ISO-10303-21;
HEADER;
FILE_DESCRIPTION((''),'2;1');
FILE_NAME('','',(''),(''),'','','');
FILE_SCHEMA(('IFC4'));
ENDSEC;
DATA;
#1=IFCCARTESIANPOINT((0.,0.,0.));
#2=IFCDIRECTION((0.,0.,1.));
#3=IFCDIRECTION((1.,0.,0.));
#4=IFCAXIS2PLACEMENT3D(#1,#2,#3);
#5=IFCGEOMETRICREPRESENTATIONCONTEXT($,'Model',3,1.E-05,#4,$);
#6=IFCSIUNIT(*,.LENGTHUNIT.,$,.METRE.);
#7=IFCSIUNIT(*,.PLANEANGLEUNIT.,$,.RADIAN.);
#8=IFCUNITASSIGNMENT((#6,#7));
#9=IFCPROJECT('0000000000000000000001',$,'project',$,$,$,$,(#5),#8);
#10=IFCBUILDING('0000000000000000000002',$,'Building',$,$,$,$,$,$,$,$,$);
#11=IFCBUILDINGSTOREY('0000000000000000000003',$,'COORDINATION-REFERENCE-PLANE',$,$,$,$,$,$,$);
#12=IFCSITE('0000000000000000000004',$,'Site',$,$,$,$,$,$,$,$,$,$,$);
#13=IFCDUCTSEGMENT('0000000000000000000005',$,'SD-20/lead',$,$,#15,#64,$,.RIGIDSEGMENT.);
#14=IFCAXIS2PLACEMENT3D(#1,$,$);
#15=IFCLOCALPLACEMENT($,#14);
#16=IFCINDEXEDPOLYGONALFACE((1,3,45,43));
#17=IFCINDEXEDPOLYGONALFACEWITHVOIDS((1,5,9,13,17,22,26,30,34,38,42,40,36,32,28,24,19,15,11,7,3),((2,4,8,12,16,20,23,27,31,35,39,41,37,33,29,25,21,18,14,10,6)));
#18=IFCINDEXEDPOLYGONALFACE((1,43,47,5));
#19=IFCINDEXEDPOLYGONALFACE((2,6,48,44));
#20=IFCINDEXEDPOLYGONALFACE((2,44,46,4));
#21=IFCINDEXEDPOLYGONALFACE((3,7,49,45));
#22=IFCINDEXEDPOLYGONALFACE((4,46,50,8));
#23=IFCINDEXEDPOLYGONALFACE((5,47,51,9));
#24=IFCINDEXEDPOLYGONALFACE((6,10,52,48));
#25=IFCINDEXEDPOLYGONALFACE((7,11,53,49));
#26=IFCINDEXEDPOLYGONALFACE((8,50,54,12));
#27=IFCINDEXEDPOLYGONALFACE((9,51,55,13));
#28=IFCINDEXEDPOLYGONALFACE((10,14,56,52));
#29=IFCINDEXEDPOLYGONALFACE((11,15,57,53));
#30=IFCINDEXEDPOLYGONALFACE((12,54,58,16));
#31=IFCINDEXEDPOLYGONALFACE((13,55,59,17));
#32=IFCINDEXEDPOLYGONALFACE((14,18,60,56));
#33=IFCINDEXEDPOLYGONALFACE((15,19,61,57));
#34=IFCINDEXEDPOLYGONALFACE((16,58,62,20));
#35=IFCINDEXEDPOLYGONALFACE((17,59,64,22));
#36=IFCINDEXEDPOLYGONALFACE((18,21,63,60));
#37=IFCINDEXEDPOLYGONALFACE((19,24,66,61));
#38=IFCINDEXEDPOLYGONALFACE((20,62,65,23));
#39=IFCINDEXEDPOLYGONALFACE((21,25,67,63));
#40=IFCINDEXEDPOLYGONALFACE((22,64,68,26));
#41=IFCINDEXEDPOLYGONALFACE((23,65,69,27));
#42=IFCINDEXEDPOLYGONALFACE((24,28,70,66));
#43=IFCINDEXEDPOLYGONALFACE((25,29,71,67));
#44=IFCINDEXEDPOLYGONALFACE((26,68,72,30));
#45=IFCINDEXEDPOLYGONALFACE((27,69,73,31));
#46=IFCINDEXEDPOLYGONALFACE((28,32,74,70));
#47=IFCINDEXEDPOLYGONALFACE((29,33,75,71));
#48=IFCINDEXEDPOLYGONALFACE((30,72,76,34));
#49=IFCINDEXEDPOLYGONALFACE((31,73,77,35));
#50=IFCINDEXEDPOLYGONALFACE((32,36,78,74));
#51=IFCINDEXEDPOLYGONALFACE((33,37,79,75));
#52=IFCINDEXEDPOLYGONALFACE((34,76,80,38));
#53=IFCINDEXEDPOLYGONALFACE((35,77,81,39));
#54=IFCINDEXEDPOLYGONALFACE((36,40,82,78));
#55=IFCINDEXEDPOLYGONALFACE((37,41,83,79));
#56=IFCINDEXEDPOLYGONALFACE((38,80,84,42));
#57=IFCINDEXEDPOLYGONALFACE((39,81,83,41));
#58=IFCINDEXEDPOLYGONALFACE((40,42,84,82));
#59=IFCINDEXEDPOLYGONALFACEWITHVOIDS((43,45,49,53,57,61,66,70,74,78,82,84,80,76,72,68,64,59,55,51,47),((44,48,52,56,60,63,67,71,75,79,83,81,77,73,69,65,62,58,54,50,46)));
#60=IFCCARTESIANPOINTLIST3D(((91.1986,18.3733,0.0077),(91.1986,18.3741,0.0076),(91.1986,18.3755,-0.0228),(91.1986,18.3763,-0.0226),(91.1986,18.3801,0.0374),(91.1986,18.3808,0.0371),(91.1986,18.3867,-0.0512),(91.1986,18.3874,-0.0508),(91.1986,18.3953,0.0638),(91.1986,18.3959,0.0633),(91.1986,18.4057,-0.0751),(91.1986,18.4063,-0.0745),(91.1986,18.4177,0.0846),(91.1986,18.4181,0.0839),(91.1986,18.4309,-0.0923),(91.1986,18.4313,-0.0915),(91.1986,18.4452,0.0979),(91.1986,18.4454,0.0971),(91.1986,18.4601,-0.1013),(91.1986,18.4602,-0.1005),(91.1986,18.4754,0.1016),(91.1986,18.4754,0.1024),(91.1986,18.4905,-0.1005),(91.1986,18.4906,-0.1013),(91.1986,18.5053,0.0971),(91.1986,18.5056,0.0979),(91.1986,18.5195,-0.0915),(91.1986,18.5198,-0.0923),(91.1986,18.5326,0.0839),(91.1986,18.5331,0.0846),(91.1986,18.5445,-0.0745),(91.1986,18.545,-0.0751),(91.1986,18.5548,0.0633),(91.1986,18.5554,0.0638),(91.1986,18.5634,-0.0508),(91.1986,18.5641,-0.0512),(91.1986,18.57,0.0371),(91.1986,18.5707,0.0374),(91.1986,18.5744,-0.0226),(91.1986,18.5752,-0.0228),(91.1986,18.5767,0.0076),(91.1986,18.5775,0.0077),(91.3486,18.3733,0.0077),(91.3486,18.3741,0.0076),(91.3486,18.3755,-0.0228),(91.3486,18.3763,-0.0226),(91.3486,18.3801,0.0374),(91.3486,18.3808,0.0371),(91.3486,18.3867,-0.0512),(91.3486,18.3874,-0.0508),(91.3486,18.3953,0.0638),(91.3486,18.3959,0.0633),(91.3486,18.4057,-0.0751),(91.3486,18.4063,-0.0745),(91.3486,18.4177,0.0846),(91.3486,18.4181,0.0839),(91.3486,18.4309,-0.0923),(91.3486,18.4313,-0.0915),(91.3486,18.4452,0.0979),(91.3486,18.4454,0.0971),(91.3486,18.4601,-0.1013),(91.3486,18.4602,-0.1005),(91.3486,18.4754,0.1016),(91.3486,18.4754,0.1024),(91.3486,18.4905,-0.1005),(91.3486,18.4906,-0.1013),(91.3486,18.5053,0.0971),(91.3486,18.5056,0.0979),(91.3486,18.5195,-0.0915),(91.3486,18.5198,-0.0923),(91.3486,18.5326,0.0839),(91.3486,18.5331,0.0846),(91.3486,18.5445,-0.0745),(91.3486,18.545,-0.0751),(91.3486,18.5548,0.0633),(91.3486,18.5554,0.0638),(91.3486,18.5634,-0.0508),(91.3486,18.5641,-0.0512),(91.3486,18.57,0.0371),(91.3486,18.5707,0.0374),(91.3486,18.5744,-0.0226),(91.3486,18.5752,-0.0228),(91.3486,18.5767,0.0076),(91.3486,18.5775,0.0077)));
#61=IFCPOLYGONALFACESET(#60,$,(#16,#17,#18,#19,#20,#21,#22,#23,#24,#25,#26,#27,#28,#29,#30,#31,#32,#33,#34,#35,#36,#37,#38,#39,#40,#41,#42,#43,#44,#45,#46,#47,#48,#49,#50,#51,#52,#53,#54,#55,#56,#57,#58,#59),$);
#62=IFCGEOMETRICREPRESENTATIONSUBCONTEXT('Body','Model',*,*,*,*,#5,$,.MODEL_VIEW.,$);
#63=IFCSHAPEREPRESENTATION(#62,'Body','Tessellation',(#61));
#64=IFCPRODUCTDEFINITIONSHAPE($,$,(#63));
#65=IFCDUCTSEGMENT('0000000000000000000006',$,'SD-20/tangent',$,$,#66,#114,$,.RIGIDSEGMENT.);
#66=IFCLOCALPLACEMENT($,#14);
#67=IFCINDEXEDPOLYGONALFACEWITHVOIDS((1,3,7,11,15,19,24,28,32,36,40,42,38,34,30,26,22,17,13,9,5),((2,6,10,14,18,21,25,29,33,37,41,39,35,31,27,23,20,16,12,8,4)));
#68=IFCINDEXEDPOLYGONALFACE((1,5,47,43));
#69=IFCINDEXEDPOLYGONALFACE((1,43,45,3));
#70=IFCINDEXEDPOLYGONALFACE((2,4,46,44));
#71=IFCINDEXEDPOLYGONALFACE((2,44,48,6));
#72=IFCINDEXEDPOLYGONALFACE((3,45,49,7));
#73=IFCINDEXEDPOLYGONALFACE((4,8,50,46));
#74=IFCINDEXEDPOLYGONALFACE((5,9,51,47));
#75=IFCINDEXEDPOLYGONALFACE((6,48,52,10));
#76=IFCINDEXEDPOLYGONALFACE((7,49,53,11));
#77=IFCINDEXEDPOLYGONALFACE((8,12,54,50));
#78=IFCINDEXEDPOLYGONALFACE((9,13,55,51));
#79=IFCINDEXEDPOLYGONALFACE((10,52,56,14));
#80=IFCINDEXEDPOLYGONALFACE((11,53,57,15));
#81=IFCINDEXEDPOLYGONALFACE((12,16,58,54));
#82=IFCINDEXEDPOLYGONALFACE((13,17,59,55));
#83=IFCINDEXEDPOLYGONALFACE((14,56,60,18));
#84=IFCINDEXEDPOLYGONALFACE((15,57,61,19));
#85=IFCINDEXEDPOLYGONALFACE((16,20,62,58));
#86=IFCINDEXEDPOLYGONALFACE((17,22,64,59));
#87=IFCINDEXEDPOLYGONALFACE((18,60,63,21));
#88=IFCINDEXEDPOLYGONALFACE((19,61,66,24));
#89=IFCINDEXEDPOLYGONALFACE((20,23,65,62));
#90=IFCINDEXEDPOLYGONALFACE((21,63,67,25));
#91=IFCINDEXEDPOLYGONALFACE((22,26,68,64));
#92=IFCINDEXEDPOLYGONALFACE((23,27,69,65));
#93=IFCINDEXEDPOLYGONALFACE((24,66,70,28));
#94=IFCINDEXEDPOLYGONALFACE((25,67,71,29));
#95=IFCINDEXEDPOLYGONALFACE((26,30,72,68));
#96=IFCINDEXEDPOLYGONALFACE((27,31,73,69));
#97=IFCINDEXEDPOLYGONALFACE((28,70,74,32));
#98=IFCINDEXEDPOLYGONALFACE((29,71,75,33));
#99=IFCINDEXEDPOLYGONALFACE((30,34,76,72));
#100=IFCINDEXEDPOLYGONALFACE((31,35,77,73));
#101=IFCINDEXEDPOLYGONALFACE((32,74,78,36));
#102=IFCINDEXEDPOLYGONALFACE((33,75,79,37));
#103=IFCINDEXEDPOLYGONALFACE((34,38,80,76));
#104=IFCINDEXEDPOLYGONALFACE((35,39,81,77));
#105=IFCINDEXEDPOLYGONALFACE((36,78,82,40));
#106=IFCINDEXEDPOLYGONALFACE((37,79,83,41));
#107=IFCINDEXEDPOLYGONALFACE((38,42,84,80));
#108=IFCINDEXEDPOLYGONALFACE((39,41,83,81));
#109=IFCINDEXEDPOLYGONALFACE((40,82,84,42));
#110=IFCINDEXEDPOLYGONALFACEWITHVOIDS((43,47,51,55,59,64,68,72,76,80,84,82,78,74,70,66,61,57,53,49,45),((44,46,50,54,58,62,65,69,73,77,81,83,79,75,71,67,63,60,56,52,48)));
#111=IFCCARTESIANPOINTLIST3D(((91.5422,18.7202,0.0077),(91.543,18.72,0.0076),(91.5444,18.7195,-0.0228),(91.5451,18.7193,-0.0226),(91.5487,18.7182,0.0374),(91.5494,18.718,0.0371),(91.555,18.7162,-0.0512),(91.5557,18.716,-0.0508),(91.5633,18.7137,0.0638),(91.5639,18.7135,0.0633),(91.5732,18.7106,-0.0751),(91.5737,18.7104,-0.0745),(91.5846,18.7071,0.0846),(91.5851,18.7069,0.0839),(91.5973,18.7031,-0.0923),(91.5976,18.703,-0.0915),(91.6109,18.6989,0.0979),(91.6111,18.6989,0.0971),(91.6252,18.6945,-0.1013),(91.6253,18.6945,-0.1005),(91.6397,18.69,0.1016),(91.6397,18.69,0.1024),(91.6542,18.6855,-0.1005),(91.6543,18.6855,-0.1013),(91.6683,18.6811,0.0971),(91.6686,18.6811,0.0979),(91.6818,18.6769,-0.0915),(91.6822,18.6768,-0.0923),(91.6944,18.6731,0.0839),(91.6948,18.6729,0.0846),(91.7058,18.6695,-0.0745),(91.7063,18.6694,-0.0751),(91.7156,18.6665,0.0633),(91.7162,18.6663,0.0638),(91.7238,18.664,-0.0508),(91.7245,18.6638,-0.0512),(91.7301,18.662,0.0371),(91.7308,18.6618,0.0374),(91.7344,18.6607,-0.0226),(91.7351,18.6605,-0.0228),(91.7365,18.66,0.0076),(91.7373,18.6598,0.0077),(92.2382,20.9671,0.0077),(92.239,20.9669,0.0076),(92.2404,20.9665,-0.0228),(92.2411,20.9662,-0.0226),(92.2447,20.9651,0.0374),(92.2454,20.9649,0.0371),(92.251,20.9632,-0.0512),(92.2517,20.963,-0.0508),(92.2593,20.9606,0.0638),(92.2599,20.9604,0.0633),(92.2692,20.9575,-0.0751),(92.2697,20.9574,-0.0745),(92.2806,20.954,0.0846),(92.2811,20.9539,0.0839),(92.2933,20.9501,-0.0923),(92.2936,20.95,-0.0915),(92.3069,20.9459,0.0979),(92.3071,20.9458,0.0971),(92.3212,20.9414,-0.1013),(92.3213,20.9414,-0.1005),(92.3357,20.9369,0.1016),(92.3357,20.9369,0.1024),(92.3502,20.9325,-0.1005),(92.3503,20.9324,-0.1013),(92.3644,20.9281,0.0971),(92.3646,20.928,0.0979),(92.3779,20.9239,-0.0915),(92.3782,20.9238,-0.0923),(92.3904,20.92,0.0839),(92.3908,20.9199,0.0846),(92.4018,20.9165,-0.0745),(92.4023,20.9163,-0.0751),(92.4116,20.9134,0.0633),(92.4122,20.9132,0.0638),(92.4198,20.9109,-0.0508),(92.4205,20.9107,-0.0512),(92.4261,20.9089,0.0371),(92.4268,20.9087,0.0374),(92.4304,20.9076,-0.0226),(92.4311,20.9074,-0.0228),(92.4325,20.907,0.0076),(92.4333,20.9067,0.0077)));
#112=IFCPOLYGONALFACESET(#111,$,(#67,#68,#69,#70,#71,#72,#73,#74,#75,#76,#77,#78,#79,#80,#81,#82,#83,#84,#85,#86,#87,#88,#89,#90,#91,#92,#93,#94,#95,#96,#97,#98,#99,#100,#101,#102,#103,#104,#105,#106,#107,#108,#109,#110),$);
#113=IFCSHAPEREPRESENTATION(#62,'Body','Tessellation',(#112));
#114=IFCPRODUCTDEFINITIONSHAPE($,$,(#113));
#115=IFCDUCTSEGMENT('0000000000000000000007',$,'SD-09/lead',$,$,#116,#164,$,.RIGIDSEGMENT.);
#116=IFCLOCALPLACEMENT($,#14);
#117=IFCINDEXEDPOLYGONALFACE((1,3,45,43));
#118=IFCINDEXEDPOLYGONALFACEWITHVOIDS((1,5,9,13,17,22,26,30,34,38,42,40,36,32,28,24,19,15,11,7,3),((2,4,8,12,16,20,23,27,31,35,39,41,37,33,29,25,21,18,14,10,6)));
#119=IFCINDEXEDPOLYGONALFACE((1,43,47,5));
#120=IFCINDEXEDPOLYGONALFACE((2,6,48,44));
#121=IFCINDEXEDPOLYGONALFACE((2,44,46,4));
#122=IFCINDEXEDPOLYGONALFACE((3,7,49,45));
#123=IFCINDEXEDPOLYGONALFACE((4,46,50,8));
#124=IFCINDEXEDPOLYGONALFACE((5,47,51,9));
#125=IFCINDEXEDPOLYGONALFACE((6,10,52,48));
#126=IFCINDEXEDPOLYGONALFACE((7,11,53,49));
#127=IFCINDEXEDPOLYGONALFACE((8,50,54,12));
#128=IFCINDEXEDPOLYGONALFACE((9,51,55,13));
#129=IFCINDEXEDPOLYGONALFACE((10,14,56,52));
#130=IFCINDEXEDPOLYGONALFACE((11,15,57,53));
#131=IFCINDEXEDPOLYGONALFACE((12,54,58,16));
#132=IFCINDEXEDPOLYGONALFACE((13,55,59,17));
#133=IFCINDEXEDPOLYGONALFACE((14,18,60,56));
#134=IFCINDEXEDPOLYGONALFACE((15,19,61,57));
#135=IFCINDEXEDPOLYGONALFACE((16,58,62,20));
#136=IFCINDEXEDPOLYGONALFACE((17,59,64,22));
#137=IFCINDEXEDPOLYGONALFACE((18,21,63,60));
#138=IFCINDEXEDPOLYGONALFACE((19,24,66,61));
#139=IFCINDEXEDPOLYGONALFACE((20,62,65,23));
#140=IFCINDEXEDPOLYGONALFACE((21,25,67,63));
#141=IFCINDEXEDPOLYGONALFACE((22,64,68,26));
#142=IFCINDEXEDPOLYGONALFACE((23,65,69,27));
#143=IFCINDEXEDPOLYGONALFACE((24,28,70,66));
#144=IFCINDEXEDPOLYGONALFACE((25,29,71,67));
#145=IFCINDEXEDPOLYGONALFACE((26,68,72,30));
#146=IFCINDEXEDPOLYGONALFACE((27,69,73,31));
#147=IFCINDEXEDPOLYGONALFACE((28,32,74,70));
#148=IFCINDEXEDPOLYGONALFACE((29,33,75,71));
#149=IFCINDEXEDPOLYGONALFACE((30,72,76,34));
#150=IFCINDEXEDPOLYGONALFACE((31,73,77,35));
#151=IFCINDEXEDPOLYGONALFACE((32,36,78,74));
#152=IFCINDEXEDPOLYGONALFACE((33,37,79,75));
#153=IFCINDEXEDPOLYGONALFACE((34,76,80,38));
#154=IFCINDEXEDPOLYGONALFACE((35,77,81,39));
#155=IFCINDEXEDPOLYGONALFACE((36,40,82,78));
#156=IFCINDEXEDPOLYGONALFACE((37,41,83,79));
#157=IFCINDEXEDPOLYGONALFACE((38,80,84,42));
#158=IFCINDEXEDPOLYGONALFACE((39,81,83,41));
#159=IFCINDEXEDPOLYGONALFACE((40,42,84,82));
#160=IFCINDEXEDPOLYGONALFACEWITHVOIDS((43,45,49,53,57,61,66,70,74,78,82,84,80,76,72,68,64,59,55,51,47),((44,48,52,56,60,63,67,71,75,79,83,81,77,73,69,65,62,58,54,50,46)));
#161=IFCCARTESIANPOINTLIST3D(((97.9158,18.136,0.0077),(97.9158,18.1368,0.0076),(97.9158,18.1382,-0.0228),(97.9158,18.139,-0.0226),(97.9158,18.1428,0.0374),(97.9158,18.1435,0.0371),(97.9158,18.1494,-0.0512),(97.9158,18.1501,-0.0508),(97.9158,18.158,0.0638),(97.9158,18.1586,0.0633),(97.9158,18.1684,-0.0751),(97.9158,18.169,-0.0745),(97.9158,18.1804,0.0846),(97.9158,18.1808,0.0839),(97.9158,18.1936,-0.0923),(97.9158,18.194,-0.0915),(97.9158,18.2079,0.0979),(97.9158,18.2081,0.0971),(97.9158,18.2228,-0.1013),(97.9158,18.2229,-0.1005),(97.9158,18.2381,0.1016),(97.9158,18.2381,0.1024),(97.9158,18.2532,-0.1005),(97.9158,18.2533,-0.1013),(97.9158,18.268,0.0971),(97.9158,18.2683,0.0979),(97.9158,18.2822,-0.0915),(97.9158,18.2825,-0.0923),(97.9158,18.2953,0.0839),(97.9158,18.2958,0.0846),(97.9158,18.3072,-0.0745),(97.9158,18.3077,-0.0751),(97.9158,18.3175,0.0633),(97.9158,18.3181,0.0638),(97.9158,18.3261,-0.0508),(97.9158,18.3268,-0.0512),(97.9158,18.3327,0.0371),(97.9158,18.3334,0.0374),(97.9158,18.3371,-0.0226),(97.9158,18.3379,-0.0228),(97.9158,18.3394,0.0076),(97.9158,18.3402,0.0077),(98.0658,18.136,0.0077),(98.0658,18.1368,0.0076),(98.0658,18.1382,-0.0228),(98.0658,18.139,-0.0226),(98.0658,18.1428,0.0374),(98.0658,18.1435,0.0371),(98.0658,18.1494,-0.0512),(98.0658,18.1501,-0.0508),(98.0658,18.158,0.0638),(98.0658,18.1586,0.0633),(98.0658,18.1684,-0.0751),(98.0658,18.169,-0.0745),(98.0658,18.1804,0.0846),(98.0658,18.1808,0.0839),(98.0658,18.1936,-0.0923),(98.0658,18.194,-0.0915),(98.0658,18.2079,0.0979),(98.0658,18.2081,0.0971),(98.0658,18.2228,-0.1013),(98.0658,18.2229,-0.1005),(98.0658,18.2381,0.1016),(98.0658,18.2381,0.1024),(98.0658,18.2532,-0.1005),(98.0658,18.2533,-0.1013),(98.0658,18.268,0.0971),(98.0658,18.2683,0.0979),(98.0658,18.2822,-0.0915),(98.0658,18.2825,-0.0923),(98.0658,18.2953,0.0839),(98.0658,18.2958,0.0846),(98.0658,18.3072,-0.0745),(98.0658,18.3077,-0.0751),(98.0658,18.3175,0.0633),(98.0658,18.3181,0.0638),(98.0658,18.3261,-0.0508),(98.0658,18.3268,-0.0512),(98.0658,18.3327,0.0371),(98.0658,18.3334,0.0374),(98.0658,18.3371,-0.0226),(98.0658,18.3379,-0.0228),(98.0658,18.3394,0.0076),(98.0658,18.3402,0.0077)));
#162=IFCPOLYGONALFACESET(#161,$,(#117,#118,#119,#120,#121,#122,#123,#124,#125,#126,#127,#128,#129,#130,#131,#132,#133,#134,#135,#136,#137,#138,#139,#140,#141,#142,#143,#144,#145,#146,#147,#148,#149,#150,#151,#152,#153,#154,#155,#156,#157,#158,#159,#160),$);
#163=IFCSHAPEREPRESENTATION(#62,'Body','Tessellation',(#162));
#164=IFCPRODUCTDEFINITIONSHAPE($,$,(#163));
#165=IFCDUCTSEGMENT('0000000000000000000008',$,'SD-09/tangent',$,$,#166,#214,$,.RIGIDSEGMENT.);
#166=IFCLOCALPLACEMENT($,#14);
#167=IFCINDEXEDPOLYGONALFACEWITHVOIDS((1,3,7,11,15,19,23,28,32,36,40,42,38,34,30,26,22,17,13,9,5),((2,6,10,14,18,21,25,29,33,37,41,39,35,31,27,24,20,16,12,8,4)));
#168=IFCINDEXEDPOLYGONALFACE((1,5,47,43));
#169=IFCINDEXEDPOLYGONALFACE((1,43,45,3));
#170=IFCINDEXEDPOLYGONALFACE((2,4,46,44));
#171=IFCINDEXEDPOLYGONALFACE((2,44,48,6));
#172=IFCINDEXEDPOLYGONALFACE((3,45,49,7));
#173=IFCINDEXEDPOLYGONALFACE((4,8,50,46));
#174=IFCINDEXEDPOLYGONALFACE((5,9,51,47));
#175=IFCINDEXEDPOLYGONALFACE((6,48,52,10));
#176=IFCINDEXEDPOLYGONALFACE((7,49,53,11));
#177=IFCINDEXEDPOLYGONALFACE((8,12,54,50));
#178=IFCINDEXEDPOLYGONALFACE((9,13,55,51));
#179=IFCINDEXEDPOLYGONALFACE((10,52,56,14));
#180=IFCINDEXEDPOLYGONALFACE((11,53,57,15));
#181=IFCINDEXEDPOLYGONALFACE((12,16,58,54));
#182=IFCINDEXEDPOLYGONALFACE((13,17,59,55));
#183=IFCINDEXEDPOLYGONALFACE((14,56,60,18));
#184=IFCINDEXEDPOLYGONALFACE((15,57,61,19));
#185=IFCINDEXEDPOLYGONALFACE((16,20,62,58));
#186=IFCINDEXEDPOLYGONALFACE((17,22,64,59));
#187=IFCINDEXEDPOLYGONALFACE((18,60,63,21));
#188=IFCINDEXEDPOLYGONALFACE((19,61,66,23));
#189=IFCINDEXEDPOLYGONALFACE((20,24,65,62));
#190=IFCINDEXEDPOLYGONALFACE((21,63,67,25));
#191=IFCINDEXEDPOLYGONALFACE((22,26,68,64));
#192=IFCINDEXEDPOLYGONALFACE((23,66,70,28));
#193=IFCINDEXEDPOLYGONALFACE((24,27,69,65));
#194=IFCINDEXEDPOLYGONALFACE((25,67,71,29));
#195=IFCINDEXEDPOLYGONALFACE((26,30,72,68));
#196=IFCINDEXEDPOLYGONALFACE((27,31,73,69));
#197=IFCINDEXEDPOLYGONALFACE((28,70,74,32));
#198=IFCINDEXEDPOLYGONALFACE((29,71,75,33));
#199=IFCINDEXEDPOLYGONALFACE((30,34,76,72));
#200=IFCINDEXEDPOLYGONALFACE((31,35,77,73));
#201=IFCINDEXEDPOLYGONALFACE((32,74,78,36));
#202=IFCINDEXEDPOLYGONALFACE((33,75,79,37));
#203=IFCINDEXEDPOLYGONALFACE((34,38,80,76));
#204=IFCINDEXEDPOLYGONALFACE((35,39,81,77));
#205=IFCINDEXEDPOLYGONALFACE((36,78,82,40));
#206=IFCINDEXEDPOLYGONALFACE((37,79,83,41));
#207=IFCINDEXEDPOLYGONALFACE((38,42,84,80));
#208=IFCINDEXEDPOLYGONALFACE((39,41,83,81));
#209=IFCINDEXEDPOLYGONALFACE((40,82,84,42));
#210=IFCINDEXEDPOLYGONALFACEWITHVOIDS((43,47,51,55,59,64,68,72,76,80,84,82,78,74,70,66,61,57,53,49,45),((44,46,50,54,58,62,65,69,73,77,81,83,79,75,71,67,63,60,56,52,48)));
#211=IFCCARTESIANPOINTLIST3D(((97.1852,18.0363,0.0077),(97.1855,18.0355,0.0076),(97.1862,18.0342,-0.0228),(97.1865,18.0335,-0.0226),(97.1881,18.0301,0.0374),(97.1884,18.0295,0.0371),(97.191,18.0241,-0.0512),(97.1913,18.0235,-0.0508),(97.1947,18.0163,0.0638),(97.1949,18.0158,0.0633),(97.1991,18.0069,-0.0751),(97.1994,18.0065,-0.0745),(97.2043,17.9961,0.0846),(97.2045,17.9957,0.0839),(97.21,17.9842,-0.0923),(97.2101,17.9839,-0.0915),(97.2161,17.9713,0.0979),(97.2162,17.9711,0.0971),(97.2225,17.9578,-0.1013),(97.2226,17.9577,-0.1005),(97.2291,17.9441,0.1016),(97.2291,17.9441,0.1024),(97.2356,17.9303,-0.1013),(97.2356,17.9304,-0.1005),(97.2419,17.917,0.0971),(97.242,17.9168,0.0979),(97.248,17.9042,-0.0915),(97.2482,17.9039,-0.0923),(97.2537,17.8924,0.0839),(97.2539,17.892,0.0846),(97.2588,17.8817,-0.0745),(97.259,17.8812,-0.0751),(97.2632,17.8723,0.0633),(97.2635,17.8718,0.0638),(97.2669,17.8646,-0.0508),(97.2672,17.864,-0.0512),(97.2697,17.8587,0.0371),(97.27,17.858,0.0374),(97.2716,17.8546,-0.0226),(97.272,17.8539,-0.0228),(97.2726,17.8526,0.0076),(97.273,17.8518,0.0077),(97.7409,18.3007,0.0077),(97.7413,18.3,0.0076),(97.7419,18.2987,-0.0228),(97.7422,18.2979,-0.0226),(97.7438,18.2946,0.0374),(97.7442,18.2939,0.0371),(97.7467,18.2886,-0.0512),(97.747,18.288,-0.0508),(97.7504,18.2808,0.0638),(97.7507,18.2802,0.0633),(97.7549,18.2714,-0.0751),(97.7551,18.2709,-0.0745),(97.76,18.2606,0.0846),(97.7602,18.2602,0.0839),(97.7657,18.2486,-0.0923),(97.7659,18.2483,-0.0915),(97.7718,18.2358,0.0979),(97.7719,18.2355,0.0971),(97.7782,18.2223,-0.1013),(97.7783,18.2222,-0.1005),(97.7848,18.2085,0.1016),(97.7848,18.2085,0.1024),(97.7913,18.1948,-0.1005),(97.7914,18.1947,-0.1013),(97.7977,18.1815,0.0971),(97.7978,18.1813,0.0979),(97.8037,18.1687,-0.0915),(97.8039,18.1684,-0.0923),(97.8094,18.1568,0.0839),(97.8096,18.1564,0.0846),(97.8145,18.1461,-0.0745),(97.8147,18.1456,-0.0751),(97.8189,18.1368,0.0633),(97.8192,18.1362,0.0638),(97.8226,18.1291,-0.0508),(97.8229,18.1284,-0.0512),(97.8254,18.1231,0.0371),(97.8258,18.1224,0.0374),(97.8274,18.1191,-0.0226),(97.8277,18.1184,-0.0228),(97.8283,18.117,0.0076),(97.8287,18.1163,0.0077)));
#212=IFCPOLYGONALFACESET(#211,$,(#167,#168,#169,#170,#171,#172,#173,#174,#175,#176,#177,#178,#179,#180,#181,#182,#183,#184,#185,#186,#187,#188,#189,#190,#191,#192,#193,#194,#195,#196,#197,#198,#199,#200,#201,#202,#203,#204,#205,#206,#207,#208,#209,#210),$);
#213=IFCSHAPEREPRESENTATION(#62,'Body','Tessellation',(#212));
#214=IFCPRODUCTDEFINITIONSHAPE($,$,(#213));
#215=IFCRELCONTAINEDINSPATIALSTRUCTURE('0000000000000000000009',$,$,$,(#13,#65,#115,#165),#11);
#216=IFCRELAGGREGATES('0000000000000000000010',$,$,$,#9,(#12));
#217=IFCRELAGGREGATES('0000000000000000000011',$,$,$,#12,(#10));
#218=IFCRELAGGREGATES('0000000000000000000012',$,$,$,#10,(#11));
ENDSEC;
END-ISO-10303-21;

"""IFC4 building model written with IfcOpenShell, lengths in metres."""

from ifc_helpers import new_model, si_unit, frame, origin_with_axes, place, context, subcontext, project, spatial, hollow_circle, extrude, element, save


model = new_model("IFC4")

# Units and contexts
model_context = context("Model", 3, precision=1e-05, world=origin_with_axes())
body_context_1 = subcontext(model_context, "Body", "Model", "MODEL_VIEW")
ifc_project = project(units=[si_unit("LENGTHUNIT", "METRE"), si_unit("PLANEANGLEUNIT", "RADIAN")], contexts=[model_context])

# Site, building, storey
site = spatial("IfcSite", under=ifc_project, Name="Site")
building = spatial("IfcBuilding", under=site, Name="Building")
storey = spatial("IfcBuildingStorey", under=building, Name="COORDINATION-REFERENCE-PLANE")

# Duct segment
for number, where, z_axis, x_axis, name in (
    (1, (91.1986, 18.4754, 0.0), (1.0, 0.0, 0.0), (0.0, 0.0, 1.0), "SD-20/lead"),
):
    element("IfcDuctSegment", number, at=place(None, frame(where, z_axis=z_axis, x_axis=x_axis)), inside=storey, Name=name, PredefinedType="RIGIDSEGMENT", context=body_context_1, shape_type="SweptSolid", body=[
        extrude(hollow_circle(Radius=0.1024, WallThickness=0.0008), origin_with_axes(), (0.0, 0.0, 1.0), 0.15),
    ])

# Duct segment
duct_segment_1_placement = place(None, frame((91.6397, 18.69, 0.0), z_axis=(0.295887, 0.955223, 0.0), x_axis=(0.0, 0.0, 1.0)))
element("IfcDuctSegment", 2, at=duct_segment_1_placement, inside=storey, Name="SD-20/tangent", PredefinedType="RIGIDSEGMENT", context=body_context_1, shape_type="SweptSolid", body=[
    extrude(hollow_circle(Radius=0.1024, WallThickness=0.0008), origin_with_axes(), (0.0, 0.0, 1.0), 2.3523),
])

# Duct segment
duct_segment_2_placement = place(None, frame((98.0658, 18.2381, 0.0), z_axis=(-1.0, 0.0, 0.0), x_axis=(0.0, 0.0, 1.0)))
element("IfcDuctSegment", 3, at=duct_segment_2_placement, inside=storey, Name="SD-09/lead", PredefinedType="RIGIDSEGMENT", context=body_context_1, shape_type="SweptSolid", body=[
    extrude(hollow_circle(Radius=0.1024, WallThickness=0.0008), origin_with_axes(), (0.0, 0.0, 1.0), 0.15),
])

# Duct segment
duct_segment_3_placement = place(None, frame((97.7848, 18.2085, 0.0), z_axis=(-0.902975, -0.429693, 0.0), x_axis=(0.0, 0.0, 1.0)))
element("IfcDuctSegment", 4, at=duct_segment_3_placement, inside=storey, Name="SD-09/tangent", PredefinedType="RIGIDSEGMENT", context=body_context_1, shape_type="SweptSolid", body=[
    extrude(hollow_circle(Radius=0.1024, WallThickness=0.0008), origin_with_axes(), (0.0, 0.0, 1.0), 0.6154),
])

save(model, "model.ifc")
